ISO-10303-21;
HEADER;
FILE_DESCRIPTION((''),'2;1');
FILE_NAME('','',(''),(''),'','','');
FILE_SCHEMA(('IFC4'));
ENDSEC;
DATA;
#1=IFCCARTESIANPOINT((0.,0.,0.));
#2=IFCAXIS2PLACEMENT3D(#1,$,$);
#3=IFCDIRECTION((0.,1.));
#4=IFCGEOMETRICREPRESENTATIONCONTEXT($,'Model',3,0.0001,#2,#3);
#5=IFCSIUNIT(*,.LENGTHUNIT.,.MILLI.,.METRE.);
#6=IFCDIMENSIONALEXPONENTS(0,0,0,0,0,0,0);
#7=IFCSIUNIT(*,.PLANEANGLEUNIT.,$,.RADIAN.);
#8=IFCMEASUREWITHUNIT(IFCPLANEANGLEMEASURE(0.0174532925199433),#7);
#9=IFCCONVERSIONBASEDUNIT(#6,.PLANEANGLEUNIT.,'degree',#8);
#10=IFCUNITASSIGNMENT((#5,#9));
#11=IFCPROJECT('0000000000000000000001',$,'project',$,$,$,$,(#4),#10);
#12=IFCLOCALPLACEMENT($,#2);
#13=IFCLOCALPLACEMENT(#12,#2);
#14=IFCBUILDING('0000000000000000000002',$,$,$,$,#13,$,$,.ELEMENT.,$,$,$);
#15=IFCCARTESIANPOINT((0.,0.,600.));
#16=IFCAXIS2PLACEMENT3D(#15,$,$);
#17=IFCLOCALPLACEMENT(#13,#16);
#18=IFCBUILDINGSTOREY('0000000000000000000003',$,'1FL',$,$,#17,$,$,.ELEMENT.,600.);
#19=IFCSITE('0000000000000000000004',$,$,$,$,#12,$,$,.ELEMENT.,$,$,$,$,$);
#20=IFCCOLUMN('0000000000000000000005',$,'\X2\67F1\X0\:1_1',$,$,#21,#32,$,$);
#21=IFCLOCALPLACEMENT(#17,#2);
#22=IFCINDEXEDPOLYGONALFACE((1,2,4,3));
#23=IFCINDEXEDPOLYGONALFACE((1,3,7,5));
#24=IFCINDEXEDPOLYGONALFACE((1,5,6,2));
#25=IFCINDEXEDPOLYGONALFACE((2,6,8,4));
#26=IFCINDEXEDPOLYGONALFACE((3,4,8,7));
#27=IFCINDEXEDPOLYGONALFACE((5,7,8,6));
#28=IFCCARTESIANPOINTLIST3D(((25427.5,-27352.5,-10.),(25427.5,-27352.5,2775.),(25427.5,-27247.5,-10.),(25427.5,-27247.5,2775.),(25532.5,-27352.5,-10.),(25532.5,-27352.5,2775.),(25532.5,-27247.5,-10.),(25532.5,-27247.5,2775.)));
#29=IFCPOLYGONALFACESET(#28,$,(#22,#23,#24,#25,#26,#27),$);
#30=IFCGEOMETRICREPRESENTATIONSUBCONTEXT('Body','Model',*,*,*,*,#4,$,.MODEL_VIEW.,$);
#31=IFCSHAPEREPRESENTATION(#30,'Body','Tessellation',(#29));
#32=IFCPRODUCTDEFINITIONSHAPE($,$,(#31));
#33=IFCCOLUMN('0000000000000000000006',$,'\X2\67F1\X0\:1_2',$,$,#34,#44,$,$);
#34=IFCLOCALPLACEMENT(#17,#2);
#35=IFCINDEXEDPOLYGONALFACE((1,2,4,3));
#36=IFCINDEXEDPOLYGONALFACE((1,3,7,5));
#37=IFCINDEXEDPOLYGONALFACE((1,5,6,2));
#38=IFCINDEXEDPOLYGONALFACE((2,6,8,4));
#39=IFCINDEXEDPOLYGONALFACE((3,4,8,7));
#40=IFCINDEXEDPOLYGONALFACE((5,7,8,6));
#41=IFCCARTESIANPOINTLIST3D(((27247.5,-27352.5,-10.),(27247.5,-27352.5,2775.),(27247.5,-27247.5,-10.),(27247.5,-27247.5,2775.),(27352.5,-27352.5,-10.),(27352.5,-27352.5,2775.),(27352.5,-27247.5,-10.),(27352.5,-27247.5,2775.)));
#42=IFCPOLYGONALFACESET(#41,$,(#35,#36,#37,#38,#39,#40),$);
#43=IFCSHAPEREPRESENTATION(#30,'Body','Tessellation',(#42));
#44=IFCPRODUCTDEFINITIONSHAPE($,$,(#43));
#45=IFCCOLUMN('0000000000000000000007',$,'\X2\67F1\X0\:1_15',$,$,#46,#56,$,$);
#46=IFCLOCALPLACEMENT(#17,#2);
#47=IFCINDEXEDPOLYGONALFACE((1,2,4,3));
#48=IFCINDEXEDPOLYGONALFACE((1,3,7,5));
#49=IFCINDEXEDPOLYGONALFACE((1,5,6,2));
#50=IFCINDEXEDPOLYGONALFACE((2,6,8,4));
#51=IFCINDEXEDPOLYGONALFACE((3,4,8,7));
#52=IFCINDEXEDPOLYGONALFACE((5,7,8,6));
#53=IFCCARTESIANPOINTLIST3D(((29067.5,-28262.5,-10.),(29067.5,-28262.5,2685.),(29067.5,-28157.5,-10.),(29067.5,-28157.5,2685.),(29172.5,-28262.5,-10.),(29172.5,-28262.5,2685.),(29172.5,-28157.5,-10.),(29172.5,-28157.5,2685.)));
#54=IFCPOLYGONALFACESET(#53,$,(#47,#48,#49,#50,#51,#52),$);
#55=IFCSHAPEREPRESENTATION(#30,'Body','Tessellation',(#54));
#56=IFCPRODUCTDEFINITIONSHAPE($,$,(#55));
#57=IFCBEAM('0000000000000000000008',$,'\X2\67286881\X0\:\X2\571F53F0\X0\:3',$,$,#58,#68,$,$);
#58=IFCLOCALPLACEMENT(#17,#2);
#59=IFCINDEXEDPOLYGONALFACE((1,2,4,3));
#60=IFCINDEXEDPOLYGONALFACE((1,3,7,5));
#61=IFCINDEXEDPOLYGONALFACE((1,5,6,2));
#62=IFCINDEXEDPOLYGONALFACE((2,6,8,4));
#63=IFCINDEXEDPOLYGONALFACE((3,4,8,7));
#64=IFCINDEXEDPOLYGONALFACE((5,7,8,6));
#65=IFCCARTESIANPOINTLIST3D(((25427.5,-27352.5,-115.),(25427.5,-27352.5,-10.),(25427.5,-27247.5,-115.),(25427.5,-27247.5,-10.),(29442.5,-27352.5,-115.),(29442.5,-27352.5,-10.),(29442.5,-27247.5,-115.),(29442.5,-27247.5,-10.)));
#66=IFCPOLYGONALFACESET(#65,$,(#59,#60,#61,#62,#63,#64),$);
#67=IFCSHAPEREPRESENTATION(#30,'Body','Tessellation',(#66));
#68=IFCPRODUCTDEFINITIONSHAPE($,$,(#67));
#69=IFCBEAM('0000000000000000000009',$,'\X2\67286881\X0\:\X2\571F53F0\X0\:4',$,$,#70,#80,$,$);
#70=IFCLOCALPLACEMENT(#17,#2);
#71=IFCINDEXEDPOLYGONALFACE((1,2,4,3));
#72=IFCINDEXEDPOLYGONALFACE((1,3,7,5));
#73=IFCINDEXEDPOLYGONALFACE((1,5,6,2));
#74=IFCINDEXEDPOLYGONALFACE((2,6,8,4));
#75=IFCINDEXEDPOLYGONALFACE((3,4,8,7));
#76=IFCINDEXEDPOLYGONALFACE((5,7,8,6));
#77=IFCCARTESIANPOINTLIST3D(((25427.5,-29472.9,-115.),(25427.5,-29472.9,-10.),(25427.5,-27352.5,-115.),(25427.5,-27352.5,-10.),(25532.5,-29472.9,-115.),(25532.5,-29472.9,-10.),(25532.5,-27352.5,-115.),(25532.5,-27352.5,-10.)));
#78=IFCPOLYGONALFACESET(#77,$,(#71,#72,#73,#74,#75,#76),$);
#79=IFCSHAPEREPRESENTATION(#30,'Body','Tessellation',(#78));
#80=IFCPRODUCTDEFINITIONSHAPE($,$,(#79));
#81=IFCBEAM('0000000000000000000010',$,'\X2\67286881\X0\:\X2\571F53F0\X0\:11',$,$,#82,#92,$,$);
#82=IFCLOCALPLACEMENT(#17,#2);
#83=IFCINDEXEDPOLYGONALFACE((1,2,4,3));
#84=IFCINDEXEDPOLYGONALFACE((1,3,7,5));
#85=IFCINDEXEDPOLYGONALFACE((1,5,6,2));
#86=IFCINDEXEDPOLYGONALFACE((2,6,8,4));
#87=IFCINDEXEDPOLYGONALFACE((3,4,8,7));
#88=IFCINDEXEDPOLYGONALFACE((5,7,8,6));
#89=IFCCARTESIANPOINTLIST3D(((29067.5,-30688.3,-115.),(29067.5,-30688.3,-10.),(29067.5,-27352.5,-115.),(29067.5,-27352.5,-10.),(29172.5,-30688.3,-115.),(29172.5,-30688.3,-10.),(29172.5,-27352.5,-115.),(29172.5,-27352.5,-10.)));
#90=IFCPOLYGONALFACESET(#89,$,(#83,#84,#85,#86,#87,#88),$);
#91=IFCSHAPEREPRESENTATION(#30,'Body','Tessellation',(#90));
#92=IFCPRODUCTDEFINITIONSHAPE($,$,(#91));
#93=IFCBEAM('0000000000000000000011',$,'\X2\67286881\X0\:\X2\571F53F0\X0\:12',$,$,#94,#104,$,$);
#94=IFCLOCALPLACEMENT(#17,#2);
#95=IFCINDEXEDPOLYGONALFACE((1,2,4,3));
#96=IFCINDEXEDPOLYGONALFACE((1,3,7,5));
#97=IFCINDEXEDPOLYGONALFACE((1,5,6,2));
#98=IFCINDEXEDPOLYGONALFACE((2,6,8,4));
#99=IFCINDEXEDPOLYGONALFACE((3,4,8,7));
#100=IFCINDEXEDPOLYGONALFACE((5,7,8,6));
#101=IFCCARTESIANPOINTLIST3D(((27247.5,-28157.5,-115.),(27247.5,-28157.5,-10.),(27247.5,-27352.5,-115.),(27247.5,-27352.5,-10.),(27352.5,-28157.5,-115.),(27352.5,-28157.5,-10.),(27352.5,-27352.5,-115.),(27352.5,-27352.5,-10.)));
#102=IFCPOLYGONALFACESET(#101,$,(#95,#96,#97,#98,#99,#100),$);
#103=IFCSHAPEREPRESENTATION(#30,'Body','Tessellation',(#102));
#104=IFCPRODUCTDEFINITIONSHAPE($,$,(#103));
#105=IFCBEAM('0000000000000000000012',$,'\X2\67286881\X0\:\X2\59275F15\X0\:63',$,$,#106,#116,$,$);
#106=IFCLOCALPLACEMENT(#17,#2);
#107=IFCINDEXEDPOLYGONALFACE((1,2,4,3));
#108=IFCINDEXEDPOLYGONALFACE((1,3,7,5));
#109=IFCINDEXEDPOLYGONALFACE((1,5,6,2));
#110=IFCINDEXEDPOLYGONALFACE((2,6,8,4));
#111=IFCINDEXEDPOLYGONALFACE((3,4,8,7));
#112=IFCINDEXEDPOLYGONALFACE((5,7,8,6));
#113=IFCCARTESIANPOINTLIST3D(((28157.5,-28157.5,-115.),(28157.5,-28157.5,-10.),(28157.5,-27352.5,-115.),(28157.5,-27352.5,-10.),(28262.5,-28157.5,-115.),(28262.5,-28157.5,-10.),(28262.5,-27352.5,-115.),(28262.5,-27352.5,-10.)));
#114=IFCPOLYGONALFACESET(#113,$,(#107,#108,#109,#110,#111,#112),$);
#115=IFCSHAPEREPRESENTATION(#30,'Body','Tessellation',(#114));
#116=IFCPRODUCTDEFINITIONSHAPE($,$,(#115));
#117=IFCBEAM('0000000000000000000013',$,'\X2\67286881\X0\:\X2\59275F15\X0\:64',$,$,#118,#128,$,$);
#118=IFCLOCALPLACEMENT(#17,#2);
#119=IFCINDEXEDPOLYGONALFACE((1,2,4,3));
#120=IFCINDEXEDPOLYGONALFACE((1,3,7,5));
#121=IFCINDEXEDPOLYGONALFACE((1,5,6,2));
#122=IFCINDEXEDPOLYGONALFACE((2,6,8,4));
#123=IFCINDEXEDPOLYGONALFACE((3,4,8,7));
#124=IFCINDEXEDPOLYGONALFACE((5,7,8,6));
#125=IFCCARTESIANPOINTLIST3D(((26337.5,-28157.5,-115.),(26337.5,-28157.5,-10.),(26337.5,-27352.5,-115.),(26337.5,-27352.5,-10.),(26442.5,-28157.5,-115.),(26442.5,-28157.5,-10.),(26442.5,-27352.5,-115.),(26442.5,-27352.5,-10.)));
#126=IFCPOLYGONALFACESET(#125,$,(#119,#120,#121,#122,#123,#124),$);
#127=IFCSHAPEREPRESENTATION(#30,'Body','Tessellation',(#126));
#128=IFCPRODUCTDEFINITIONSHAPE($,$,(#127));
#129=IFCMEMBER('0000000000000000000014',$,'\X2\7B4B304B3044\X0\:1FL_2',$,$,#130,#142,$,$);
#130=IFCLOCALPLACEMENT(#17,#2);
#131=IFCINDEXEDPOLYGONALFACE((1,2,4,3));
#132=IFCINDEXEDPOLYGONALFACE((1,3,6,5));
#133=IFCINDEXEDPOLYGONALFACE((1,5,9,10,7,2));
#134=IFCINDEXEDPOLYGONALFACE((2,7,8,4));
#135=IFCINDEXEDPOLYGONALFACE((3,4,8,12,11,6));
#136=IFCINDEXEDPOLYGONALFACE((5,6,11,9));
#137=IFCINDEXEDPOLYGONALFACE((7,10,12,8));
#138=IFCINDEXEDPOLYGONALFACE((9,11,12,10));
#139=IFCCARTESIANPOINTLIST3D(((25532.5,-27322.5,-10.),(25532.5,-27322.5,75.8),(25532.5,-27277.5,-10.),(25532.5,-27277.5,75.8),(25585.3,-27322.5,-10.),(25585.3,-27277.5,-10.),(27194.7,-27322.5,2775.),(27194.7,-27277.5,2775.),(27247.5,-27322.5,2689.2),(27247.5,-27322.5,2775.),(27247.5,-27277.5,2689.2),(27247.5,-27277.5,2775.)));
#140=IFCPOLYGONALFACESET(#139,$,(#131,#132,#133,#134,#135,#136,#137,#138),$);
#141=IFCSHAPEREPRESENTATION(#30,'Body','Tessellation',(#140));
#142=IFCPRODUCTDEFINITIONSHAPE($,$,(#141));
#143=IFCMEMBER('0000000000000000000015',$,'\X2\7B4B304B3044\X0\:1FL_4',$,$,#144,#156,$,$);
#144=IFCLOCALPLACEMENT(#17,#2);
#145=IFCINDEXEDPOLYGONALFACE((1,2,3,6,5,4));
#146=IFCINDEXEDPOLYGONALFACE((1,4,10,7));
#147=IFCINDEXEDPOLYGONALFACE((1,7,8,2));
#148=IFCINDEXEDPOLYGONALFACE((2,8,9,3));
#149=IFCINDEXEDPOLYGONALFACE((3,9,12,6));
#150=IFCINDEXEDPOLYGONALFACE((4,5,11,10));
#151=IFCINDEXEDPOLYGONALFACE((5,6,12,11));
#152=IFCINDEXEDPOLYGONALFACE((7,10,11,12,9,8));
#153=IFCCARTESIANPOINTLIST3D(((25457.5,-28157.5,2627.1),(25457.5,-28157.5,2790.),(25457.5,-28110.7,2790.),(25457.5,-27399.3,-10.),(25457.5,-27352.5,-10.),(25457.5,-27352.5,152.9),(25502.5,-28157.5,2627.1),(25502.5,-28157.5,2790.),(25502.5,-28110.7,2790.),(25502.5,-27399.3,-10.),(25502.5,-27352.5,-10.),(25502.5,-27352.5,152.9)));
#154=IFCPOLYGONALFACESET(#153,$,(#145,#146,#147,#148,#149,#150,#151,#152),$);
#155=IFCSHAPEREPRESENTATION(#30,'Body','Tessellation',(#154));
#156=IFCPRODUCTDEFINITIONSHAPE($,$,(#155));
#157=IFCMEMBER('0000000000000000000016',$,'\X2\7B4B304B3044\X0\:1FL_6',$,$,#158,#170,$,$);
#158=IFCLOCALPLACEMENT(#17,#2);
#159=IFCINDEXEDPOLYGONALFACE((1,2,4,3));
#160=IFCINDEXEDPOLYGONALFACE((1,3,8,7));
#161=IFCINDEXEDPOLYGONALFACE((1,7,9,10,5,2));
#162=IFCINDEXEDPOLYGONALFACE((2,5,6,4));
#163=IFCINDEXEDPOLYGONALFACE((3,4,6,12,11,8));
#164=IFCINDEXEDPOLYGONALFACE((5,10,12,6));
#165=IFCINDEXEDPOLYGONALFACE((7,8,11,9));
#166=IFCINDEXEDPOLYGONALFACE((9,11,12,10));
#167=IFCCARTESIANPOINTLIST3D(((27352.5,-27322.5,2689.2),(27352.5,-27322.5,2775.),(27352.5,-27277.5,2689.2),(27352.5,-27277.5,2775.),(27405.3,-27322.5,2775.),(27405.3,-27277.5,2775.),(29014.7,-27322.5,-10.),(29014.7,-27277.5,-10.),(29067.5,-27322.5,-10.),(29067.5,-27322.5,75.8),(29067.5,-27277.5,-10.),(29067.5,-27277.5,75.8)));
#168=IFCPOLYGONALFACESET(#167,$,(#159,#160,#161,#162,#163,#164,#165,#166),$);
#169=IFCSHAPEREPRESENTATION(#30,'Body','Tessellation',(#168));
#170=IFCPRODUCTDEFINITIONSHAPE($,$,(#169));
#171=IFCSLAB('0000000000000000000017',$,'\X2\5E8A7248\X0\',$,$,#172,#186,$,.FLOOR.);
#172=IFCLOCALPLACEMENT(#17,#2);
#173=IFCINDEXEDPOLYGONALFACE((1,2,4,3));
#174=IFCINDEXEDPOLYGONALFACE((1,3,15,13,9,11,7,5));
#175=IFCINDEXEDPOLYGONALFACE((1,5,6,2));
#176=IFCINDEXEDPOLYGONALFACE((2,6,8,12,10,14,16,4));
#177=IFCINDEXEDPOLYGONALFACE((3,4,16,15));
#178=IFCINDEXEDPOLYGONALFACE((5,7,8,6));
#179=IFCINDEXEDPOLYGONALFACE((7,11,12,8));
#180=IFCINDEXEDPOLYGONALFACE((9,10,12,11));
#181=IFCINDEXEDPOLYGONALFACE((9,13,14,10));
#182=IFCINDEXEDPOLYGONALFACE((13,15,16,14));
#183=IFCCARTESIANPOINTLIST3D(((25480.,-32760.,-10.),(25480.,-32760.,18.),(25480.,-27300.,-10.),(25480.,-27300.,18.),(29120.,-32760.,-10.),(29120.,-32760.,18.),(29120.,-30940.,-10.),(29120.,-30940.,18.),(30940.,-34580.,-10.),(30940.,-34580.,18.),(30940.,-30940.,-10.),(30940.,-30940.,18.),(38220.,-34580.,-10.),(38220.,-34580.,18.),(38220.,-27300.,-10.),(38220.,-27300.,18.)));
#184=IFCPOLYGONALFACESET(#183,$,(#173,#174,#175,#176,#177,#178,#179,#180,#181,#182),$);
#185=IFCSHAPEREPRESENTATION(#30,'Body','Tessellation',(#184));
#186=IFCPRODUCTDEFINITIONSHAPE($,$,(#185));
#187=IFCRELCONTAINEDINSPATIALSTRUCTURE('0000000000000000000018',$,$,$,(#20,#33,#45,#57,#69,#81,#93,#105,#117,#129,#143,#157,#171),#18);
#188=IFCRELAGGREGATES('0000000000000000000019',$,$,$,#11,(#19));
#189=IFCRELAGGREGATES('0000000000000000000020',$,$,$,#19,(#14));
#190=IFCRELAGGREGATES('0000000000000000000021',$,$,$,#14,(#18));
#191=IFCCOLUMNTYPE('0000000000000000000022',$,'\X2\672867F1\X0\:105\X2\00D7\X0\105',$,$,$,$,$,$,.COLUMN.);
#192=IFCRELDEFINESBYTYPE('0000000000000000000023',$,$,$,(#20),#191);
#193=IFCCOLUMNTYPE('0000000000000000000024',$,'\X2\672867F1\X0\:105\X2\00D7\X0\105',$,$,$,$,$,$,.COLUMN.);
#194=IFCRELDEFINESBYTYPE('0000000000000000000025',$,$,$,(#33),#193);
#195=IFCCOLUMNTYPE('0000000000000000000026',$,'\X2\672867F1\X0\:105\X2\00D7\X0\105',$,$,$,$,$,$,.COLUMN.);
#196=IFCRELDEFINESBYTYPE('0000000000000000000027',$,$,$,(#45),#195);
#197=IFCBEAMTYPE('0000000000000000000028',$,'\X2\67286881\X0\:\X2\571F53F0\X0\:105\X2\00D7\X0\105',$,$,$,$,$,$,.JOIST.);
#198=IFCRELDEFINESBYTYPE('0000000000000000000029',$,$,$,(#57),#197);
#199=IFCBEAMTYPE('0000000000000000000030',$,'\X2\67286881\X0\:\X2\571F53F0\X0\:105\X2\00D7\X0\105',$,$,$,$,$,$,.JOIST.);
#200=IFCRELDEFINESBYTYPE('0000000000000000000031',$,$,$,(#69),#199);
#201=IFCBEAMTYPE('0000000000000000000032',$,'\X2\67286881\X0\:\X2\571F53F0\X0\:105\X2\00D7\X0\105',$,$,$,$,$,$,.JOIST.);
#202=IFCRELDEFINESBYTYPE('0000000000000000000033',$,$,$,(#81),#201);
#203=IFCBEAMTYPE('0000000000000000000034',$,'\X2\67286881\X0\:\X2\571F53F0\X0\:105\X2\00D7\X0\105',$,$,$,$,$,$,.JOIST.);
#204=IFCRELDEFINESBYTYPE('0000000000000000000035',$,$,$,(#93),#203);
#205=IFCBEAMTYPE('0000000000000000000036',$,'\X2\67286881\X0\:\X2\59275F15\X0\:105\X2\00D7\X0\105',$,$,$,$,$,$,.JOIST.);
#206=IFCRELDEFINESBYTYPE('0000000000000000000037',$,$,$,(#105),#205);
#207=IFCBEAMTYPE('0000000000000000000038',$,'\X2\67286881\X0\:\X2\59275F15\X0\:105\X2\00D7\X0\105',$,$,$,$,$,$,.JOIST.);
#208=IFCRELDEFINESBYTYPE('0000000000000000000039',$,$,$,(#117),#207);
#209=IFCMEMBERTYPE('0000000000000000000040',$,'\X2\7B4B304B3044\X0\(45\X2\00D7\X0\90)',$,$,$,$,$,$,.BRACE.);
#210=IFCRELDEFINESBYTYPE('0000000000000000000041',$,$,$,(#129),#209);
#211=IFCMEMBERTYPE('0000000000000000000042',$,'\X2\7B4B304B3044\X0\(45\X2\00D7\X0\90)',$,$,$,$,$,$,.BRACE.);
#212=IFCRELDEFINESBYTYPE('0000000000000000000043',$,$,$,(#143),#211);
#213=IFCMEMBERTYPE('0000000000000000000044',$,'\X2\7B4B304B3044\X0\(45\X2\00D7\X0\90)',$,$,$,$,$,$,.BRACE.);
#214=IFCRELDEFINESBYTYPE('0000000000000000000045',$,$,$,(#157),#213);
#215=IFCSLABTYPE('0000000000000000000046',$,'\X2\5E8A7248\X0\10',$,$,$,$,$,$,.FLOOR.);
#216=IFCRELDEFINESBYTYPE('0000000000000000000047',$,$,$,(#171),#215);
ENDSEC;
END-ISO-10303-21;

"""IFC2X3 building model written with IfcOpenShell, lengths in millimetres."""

from ifc_helpers import new_model, entity, si_unit, converted_unit, direction, frame, origin, origin_with_axes, origin_2d, place, context, subcontext, project, spatial, polyline, rectangle, outline, extrude, type_object, element, save


model = new_model("IFC2X3")

# Units and contexts
model_context = context("Model", 3, precision=0.0001, world=origin(), true_north=direction((0.0, 1.0)))
body_context = subcontext(model_context, "Body", "Model", "MODEL_VIEW")
ifc_project = project(units=[si_unit("LENGTHUNIT", "METRE", prefix="MILLI"), converted_unit("PLANEANGLEUNIT", "degree", entity("IfcPlaneAngleMeasure", 0.0174532925199433), si_unit("PLANEANGLEUNIT", "RADIAN"), dimensions=[0, 0, 0, 0, 0, 0, 0])], contexts=[model_context])

# Site, building, storey
site_placement = place(None, origin())
site = spatial("IfcSite", under=ifc_project, at=site_placement, CompositionType="ELEMENT")
building_placement = place(site_placement, origin())
building = spatial("IfcBuilding", under=site, at=building_placement, CompositionType="ELEMENT")
storey_placement = place(building_placement, frame((0.0, 0.0, 600.0)))
storey = spatial("IfcBuildingStorey", under=building, at=storey_placement, Name="1FL", CompositionType="ELEMENT", Elevation=600.0)

# Columns
column_type_1 = type_object("IfcColumnType", Name="木柱:105×105", PredefinedType="COLUMN")
column_1_placement = place(storey_placement, frame((25480.0, -27300.0, -10.0)))
element("IfcColumn", 1, at=column_1_placement, inside=storey, type_object=column_type_1, Name="柱:1_1", context=body_context, shape_type="SweptSolid", body=[
    extrude(rectangle(XDim=105.0, YDim=105.0, at=origin_2d()), origin_with_axes(), (0.0, 0.0, 1.0), 2785.0),
])
column_type_2 = type_object("IfcColumnType", Name="木柱:105×105", PredefinedType="COLUMN")
column_2_placement = place(storey_placement, frame((27300.0, -27300.0, -10.0)))
element("IfcColumn", 2, at=column_2_placement, inside=storey, type_object=column_type_2, Name="柱:1_2", context=body_context, shape_type="SweptSolid", body=[
    extrude(rectangle(XDim=105.0, YDim=105.0, at=origin_2d()), origin_with_axes(), (0.0, 0.0, 1.0), 2785.0),
])
column_type_3 = type_object("IfcColumnType", Name="木柱:105×105", PredefinedType="COLUMN")
column_3_placement = place(storey_placement, frame((29120.0, -28210.0, -10.0)))
element("IfcColumn", 3, at=column_3_placement, inside=storey, type_object=column_type_3, Name="柱:1_15", context=body_context, shape_type="SweptSolid", body=[
    extrude(rectangle(XDim=105.0, YDim=105.0, at=origin_2d()), origin_with_axes(), (0.0, 0.0, 1.0), 2695.0),
])

# Beams
beam_type_1 = type_object("IfcBeamType", Name="木梁:土台:105×105", PredefinedType="JOIST")
beam_1_placement = place(storey_placement, frame((25427.5, -27300.0, -62.5), z_axis=(1.0, 0.0, 0.0), x_axis=(0.0, 1.0, 0.0)))
element("IfcBeam", 4, at=beam_1_placement, inside=storey, type_object=beam_type_1, Name="木梁:土台:3", context=body_context, shape_type="SweptSolid", body=[
    extrude(rectangle(XDim=105.0, YDim=105.0, at=origin_2d()), origin_with_axes(), (0.0, 0.0, 1.0), 4015.0),
])
beam_type_2 = type_object("IfcBeamType", Name="木梁:土台:105×105", PredefinedType="JOIST")
beam_2_placement = place(storey_placement, frame((25480.0, -27352.5, -62.5), z_axis=(0.0, -1.0, 0.0), x_axis=(1.0, 0.0, 0.0)))
element("IfcBeam", 5, at=beam_2_placement, inside=storey, type_object=beam_type_2, Name="木梁:土台:4", context=body_context, shape_type="SweptSolid", body=[
    extrude(rectangle(XDim=105.0, YDim=105.0, at=origin_2d()), origin_with_axes(), (0.0, 0.0, 1.0), 2120.4),
])
beam_type_3 = type_object("IfcBeamType", Name="木梁:土台:105×105", PredefinedType="JOIST")
beam_3_placement = place(storey_placement, frame((29120.0, -27352.5, -62.5), z_axis=(0.0, -1.0, 0.0), x_axis=(1.0, 0.0, 0.0)))
element("IfcBeam", 6, at=beam_3_placement, inside=storey, type_object=beam_type_3, Name="木梁:土台:11", context=body_context, shape_type="SweptSolid", body=[
    extrude(rectangle(XDim=105.0, YDim=105.0, at=origin_2d()), origin_with_axes(), (0.0, 0.0, 1.0), 3335.8),
])
beam_type_4 = type_object("IfcBeamType", Name="木梁:土台:105×105", PredefinedType="JOIST")
beam_4_placement = place(storey_placement, frame((27300.0, -27352.5, -62.5), z_axis=(0.0, -1.0, 0.0), x_axis=(1.0, 0.0, 0.0)))
element("IfcBeam", 7, at=beam_4_placement, inside=storey, type_object=beam_type_4, Name="木梁:土台:12", context=body_context, shape_type="SweptSolid", body=[
    extrude(rectangle(XDim=105.0, YDim=105.0, at=origin_2d()), origin_with_axes(), (0.0, 0.0, 1.0), 805.0),
])
beam_type_5 = type_object("IfcBeamType", Name="木梁:大引:105×105", PredefinedType="JOIST")
beam_5_placement = place(storey_placement, frame((28210.0, -27352.5, -62.5), z_axis=(0.0, -1.0, 0.0), x_axis=(1.0, 0.0, 0.0)))
element("IfcBeam", 8, at=beam_5_placement, inside=storey, type_object=beam_type_5, Name="木梁:大引:63", context=body_context, shape_type="SweptSolid", body=[
    extrude(rectangle(XDim=105.0, YDim=105.0, at=origin_2d()), origin_with_axes(), (0.0, 0.0, 1.0), 805.0),
])
beam_type_6 = type_object("IfcBeamType", Name="木梁:大引:105×105", PredefinedType="JOIST")
beam_6_placement = place(storey_placement, frame((26390.0, -27352.5, -62.5), z_axis=(0.0, -1.0, 0.0), x_axis=(1.0, 0.0, 0.0)))
element("IfcBeam", 9, at=beam_6_placement, inside=storey, type_object=beam_type_6, Name="木梁:大引:64", context=body_context, shape_type="SweptSolid", body=[
    extrude(rectangle(XDim=105.0, YDim=105.0, at=origin_2d()), origin_with_axes(), (0.0, 0.0, 1.0), 805.0),
])

# Members
member_type_1 = type_object("IfcMemberType", Name="筋かい(45×90)", PredefinedType="BRACE")
member_1_placement = place(storey_placement, frame((25532.5, -27300.0, -10.0), z_axis=(0.524353, 0.0, 0.851501), x_axis=(-0.851501, 0.0, 0.524353)))
element("IfcMember", 10, at=member_1_placement, inside=storey, type_object=member_type_1, Name="筋かい:1FL_2", context=body_context, shape_type="SweptSolid", body=[
    extrude(outline(polyline([(0.0, 0.0), (27.7, -45.0), (3197.6, -45.0), (3270.7, 0.0), (3243.0, 45.0), (73.1, 45.0), (0.0, 0.0)])), frame((0.0, -22.5, 0.0), z_axis=(0.0, 1.0, 0.0), x_axis=(0.0, 0.0, 1.0)), (0.0, 0.0, 1.0), 45.0),
])
member_type_2 = type_object("IfcMemberType", Name="筋かい(45×90)", PredefinedType="BRACE")
member_2_placement = place(storey_placement, frame((25480.0, -27352.5, -10.0), z_axis=(0.0, -0.276307, 0.961069), x_axis=(0.0, 0.961069, 0.276307)))
element("IfcMember", 11, at=member_2_placement, inside=storey, type_object=member_type_2, Name="筋かい:1FL_4", context=body_context, shape_type="SweptSolid", body=[
    extrude(outline(polyline([(0.0, 0.0), (12.9, -45.0), (2756.9, -45.0), (2913.4, 0.0), (2900.5, 45.0), (156.5, 45.0), (0.0, 0.0)])), frame((0.0, -22.5, 0.0), z_axis=(0.0, 1.0, 0.0), x_axis=(0.0, 0.0, 1.0)), (0.0, 0.0, 1.0), 45.0),
])
member_type_3 = type_object("IfcMemberType", Name="筋かい(45×90)", PredefinedType="BRACE")
member_3_placement = place(storey_placement, frame((29067.5, -27300.0, -10.0), z_axis=(-0.524353, 0.0, 0.851501), x_axis=(0.851501, 0.0, 0.524353)))
element("IfcMember", 12, at=member_3_placement, inside=storey, type_object=member_type_3, Name="筋かい:1FL_6", context=body_context, shape_type="SweptSolid", body=[
    extrude(outline(polyline([(0.0, 0.0), (27.7, -45.0), (3197.6, -45.0), (3270.7, 0.0), (3243.0, 45.0), (73.1, 45.0), (0.0, 0.0)])), frame((0.0, -22.5, 0.0), z_axis=(0.0, 1.0, 0.0), x_axis=(0.0, 0.0, 1.0)), (0.0, 0.0, 1.0), 45.0),
])

# Slab
slab_type = type_object("IfcSlabType", Name="床版10", PredefinedType="FLOOR")
slab_placement = place(storey_placement, frame((0.0, 0.0, -10.0), z_axis=(0.0, 0.0, 1.0), x_axis=(1.0, 0.0, 0.0)))
element("IfcSlab", 13, at=slab_placement, inside=storey, type_object=slab_type, Name="床版", PredefinedType="FLOOR", context=body_context, shape_type="SweptSolid", body=[
    extrude(outline(polyline([(30940.0, -34580.0, 0.0), (38220.0, -34580.0, 0.0), (38220.0, -27300.0, 0.0), (25480.0, -27300.0, 0.0), (25480.0, -32760.0, 0.0), (29120.0, -32760.0, 0.0), (29120.0, -30940.0, 0.0), (30940.0, -30940.0, 0.0), (30940.0, -34580.0, 0.0)])), origin_with_axes(), (0.0, 0.0, 1.0), 28.0),
])

save(model, "model.ifc")
